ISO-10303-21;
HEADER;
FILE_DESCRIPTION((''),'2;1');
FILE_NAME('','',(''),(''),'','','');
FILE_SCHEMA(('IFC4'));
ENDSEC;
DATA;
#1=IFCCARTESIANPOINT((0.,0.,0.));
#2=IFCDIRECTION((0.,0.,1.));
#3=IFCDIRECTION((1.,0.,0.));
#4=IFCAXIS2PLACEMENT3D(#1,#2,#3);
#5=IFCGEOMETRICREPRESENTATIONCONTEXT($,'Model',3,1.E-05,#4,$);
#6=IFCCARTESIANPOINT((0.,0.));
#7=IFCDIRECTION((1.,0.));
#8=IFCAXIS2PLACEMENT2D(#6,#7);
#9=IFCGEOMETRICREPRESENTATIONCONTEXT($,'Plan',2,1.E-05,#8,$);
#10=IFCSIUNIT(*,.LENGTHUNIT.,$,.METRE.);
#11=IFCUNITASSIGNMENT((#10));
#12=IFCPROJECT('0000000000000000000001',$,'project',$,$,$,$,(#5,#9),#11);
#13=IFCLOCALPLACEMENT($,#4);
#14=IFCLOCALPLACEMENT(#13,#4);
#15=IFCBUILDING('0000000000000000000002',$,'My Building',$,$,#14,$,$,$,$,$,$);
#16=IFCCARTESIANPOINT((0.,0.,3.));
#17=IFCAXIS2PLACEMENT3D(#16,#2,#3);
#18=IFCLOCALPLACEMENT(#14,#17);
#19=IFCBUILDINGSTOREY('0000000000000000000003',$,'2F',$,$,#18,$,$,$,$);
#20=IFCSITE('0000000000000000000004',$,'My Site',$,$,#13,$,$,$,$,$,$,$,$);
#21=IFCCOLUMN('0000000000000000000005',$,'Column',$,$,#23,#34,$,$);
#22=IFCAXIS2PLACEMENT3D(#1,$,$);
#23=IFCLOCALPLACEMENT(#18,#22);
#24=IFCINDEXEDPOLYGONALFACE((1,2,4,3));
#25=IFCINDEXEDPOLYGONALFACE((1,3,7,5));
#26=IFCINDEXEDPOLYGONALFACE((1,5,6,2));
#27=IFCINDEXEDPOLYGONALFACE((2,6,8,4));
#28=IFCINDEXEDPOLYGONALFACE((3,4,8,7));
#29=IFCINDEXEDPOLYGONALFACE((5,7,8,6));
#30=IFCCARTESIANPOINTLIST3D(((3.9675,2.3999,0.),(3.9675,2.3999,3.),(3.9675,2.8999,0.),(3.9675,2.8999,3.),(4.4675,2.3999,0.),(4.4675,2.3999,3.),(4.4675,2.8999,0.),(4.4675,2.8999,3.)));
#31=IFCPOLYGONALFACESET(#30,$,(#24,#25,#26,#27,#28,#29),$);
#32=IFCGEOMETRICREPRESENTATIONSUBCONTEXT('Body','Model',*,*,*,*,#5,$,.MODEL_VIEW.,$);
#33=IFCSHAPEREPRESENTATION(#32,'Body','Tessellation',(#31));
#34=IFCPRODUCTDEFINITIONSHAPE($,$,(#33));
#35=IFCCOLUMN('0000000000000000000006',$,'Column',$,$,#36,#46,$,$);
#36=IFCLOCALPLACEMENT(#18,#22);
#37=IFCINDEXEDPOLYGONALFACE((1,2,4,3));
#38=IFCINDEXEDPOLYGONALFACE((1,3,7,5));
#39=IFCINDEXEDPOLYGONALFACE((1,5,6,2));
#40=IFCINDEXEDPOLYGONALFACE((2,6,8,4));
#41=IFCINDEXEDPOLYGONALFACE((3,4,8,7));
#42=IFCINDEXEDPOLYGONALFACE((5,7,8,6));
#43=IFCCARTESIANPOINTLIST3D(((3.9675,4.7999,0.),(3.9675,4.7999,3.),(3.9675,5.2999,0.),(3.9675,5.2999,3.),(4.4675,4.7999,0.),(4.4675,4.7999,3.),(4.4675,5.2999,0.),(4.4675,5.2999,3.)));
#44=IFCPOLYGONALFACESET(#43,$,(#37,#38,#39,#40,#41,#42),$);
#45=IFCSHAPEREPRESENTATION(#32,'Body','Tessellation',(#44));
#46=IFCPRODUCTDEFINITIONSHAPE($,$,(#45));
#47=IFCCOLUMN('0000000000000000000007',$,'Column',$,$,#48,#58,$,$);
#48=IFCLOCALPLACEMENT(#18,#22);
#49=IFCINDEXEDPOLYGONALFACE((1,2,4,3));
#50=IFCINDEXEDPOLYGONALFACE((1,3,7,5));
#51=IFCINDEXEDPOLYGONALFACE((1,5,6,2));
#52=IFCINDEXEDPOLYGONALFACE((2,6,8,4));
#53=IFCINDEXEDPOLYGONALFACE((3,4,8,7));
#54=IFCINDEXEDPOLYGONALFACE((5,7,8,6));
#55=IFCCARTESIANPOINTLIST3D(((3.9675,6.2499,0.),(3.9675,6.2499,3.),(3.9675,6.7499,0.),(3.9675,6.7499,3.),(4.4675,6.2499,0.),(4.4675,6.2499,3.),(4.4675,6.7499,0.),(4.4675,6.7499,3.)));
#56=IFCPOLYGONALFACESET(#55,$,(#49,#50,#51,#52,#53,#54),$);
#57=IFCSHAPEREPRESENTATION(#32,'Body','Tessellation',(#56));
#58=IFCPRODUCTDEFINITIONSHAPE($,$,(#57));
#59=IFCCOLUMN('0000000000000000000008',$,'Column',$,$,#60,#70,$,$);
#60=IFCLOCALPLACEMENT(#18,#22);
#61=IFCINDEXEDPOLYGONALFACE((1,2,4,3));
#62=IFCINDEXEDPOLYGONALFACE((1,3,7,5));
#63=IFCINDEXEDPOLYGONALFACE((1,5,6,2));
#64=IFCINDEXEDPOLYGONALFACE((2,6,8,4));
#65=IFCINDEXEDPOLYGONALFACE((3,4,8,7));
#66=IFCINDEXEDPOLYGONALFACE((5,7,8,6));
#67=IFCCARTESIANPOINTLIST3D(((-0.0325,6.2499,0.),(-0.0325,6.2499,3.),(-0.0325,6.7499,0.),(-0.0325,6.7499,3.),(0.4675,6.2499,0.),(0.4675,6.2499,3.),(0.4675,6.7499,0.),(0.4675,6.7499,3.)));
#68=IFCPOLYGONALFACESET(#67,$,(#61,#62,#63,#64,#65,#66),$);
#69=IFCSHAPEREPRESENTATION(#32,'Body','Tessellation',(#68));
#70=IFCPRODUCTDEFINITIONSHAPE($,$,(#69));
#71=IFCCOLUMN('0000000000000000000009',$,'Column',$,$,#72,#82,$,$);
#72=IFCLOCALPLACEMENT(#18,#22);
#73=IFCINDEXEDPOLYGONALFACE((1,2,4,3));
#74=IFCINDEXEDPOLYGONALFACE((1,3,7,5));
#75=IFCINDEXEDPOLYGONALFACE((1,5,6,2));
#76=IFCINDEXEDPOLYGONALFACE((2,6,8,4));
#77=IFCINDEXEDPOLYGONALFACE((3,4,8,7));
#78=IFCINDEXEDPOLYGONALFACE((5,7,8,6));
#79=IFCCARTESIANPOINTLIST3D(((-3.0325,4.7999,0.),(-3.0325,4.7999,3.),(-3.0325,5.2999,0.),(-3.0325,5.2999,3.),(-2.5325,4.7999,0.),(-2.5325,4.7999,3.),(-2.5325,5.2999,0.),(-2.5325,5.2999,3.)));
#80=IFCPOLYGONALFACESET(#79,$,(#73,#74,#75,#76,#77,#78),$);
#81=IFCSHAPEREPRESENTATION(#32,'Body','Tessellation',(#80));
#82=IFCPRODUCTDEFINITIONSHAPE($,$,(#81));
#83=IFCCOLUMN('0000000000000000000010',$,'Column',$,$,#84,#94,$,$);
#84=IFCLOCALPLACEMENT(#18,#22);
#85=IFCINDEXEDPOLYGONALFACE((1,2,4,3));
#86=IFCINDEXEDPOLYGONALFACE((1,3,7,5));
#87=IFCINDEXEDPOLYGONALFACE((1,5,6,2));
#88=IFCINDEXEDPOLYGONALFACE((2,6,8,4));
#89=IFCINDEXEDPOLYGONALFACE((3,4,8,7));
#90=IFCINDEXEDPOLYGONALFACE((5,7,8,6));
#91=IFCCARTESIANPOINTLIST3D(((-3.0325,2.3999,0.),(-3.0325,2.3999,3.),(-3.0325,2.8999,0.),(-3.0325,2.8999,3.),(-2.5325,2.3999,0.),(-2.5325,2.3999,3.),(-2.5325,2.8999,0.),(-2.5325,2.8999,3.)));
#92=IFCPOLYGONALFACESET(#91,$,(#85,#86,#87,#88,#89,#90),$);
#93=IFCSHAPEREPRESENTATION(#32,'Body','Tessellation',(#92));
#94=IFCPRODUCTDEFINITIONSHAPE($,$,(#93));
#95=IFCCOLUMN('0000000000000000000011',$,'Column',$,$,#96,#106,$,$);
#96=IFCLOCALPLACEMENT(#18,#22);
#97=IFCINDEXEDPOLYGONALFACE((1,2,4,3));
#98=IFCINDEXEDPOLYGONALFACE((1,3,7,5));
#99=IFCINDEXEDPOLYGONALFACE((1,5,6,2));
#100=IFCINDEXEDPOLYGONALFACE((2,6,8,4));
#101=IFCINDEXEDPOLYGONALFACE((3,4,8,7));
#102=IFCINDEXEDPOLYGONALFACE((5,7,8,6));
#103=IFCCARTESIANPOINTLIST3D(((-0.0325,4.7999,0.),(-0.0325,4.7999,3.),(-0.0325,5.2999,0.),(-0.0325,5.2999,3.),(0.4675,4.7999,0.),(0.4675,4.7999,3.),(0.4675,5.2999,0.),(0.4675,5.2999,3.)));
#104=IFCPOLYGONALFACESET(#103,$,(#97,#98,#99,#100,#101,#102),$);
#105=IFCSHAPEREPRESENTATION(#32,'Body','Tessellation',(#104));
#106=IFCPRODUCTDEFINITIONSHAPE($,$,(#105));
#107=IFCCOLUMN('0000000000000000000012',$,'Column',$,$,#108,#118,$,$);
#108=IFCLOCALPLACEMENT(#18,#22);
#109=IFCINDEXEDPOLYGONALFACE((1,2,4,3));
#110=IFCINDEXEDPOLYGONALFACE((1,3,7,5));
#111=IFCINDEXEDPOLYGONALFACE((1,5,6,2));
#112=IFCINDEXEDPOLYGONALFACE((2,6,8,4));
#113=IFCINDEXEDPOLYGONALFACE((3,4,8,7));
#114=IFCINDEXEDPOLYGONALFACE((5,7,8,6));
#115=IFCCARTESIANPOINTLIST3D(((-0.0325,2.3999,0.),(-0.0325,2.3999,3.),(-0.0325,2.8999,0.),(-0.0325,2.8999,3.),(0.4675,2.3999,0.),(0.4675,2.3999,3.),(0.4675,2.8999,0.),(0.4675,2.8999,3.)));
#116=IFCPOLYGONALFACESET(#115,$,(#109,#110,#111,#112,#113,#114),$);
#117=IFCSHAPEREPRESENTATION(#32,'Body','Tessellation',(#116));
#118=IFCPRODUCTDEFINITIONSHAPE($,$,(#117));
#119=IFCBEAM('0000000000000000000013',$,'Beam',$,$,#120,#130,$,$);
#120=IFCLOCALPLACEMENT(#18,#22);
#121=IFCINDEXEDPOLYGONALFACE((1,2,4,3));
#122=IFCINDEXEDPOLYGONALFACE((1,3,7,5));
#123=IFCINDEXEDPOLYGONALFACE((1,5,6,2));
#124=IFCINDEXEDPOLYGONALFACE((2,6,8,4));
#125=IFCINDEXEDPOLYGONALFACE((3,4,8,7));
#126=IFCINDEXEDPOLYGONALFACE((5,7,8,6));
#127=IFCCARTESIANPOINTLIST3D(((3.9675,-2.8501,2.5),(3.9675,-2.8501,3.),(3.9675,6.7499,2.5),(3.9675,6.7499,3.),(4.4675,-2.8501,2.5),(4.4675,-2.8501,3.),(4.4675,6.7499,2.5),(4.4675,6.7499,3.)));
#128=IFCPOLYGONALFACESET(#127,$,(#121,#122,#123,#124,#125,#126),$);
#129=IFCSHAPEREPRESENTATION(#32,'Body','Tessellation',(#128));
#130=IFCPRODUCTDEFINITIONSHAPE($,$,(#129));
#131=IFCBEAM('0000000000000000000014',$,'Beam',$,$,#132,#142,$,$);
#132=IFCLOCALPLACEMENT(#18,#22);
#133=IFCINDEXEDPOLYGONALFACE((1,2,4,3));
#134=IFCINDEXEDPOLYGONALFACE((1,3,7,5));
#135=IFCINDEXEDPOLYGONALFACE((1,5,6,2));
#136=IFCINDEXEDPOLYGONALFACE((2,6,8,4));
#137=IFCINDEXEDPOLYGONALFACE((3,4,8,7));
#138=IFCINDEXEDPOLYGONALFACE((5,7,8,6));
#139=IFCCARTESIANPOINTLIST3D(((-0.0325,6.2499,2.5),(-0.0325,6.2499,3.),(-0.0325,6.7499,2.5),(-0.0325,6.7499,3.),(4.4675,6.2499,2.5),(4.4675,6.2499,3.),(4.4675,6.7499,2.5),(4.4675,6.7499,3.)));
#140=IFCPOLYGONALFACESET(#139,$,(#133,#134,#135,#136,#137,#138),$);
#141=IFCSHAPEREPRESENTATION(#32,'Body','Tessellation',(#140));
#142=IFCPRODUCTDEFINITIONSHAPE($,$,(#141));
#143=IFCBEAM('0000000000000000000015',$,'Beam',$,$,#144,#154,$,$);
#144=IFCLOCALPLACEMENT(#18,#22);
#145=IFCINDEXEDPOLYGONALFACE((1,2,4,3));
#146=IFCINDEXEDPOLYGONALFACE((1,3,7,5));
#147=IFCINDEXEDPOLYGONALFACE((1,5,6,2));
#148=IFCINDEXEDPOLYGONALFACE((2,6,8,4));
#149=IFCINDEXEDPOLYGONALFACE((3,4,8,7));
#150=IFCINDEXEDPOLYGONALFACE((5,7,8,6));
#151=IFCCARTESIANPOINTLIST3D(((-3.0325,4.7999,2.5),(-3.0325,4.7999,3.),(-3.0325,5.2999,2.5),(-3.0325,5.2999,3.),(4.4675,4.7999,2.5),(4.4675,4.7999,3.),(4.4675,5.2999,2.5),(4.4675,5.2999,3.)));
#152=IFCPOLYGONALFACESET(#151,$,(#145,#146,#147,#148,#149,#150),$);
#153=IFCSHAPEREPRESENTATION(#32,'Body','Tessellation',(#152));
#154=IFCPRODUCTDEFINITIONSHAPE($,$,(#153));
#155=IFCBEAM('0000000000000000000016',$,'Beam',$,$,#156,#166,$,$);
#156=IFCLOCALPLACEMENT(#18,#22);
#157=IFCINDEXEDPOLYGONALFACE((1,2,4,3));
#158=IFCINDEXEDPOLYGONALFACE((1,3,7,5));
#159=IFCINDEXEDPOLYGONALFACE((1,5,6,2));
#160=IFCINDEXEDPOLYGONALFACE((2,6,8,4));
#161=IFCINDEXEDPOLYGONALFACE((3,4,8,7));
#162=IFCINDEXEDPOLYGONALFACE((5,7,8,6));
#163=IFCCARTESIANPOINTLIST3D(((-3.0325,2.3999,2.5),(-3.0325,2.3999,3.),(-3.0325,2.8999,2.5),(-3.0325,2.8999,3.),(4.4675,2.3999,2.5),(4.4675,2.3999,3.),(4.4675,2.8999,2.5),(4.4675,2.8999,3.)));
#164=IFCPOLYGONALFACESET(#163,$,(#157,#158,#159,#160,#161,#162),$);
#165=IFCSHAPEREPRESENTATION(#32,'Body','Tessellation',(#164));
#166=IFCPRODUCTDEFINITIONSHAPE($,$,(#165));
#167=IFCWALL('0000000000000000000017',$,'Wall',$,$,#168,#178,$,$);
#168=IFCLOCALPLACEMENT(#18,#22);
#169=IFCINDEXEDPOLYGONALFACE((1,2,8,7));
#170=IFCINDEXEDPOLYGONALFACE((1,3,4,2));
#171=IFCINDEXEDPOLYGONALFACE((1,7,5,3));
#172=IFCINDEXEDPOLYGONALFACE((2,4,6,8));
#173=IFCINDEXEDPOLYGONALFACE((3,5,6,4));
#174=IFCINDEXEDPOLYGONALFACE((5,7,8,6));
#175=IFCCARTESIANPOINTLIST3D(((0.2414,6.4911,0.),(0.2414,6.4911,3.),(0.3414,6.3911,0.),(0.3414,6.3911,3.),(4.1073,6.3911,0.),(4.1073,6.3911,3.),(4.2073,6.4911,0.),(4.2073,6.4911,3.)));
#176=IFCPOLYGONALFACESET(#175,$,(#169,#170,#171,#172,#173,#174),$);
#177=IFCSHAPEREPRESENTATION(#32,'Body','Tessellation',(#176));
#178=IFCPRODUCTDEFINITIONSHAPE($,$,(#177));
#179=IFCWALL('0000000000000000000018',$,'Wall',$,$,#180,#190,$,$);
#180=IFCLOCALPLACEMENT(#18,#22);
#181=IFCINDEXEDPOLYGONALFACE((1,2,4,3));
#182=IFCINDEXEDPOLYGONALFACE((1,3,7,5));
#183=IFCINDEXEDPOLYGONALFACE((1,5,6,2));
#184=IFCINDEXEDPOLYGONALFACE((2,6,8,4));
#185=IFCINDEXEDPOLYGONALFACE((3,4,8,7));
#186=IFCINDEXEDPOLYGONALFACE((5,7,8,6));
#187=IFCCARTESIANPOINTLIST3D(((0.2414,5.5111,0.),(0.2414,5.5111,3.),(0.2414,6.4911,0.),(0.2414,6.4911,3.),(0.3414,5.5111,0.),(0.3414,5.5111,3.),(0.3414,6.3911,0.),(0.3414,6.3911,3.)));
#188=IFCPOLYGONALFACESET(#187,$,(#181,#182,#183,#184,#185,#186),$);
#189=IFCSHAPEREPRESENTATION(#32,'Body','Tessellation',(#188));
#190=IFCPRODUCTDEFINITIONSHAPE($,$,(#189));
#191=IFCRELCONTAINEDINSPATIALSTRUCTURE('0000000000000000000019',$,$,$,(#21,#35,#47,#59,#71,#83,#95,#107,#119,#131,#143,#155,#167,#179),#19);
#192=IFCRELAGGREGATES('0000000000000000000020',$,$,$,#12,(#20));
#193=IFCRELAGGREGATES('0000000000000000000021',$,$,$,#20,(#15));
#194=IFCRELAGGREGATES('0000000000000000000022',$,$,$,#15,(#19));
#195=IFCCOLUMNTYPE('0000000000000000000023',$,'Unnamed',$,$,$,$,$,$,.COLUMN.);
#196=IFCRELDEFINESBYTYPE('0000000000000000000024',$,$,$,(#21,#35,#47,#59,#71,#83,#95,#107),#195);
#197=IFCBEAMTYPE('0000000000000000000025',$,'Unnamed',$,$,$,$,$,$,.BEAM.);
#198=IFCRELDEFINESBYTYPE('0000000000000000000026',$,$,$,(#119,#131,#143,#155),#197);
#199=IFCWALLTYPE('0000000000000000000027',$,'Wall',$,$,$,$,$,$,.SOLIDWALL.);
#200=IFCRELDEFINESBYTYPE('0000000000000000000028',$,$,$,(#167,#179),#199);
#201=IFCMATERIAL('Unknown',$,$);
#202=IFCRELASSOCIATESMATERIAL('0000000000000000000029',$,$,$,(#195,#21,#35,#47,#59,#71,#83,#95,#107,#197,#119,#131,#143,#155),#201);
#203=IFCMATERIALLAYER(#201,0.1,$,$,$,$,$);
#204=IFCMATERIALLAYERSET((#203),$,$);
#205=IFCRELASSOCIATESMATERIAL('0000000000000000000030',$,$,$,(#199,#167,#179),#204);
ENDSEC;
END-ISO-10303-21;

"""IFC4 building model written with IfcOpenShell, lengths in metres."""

from ifc_helpers import new_model, si_unit, frame, origin_with_axes, origin_2d_with_axis, place, context, subcontext, project, spatial, line, indexed_curve, rectangle, outline, extrude, material, layer, layer_set, layer_usage, material_profile, profile_set, profile_usage, type_object, element, save


model = new_model("IFC4")

# Units and contexts
model_context = context("Model", 3, precision=1e-05, world=origin_with_axes())
plan_context = context("Plan", 2, precision=1e-05, world=origin_2d_with_axis())
body_context_1 = subcontext(model_context, "Body", "Model", "MODEL_VIEW")
ifc_project = project(units=[si_unit("LENGTHUNIT", "METRE")], contexts=[model_context, plan_context])

# Site, building, storey
site_placement = place(None, origin_with_axes())
site = spatial("IfcSite", under=ifc_project, at=site_placement, Name="My Site")
building_placement = place(site_placement, origin_with_axes())
building = spatial("IfcBuilding", under=site, at=building_placement, Name="My Building")
storey_placement = place(building_placement, frame((0.0, 0.0, 3.0), z_axis=(0.0, 0.0, 1.0), x_axis=(1.0, 0.0, 0.0)))
storey = spatial("IfcBuildingStorey", under=building, at=storey_placement, Name="2F")

# Columns
ifc_material = material(Name="Unknown")
ifc_material_profile_1 = material_profile(ifc_material, rectangle(XDim=0.5, YDim=0.5))
ifc_profile_set_1 = profile_set([ifc_material_profile_1])
ifc_profile_usage_1 = profile_usage(ifc_profile_set_1, cardinal=7)
column_type = type_object("IfcColumnType", Name="Unnamed", PredefinedType="COLUMN", material=ifc_profile_set_1)
column_1_placement = place(storey_placement, frame((4.4675, 2.8999, 0.0), z_axis=(0.0, 0.0, 1.0), x_axis=(1.0, 0.0, 0.0)))
element("IfcColumn", 1, at=column_1_placement, inside=storey, type_object=column_type, material=ifc_profile_usage_1, Name="Column", context=body_context_1, shape_type="SweptSolid", body=[
    extrude(rectangle(XDim=0.5, YDim=0.5), frame((-0.25, -0.25, 0.0), z_axis=(0.0, 0.0, 1.0), x_axis=(1.0, 0.0, 0.0)), (0.0, 0.0, 1.0), 3.0),
])
ifc_profile_usage_2 = profile_usage(ifc_profile_set_1, cardinal=7)
column_2_placement = place(storey_placement, frame((4.4675, 5.2999, 0.0), z_axis=(0.0, 0.0, 1.0), x_axis=(1.0, 0.0, 0.0)))
element("IfcColumn", 2, at=column_2_placement, inside=storey, type_object=column_type, material=ifc_profile_usage_2, Name="Column", context=body_context_1, shape_type="SweptSolid", body=[
    extrude(rectangle(XDim=0.5, YDim=0.5), frame((-0.25, -0.25, 0.0), z_axis=(0.0, 0.0, 1.0), x_axis=(1.0, 0.0, 0.0)), (0.0, 0.0, 1.0), 3.0),
])
ifc_profile_usage_3 = profile_usage(ifc_profile_set_1, cardinal=7)
column_3_placement = place(storey_placement, frame((4.4675, 6.7499, 0.0), z_axis=(0.0, 0.0, 1.0), x_axis=(1.0, 0.0, 0.0)))
element("IfcColumn", 3, at=column_3_placement, inside=storey, type_object=column_type, material=ifc_profile_usage_3, Name="Column", context=body_context_1, shape_type="SweptSolid", body=[
    extrude(rectangle(XDim=0.5, YDim=0.5), frame((-0.25, -0.25, 0.0), z_axis=(0.0, 0.0, 1.0), x_axis=(1.0, 0.0, 0.0)), (0.0, 0.0, 1.0), 3.0),
])
ifc_profile_usage_4 = profile_usage(ifc_profile_set_1, cardinal=7)
column_4_placement = place(storey_placement, frame((0.4675, 6.7499, 0.0), z_axis=(0.0, 0.0, 1.0), x_axis=(1.0, 0.0, 0.0)))
element("IfcColumn", 4, at=column_4_placement, inside=storey, type_object=column_type, material=ifc_profile_usage_4, Name="Column", context=body_context_1, shape_type="SweptSolid", body=[
    extrude(rectangle(XDim=0.5, YDim=0.5), frame((-0.25, -0.25, 0.0), z_axis=(0.0, 0.0, 1.0), x_axis=(1.0, 0.0, 0.0)), (0.0, 0.0, 1.0), 3.0),
])
ifc_profile_usage_5 = profile_usage(ifc_profile_set_1, cardinal=9)
column_5_placement = place(storey_placement, frame((-3.0325, 5.2999, 0.0), z_axis=(0.0, 0.0, 1.0), x_axis=(1.0, 0.0, 0.0)))
element("IfcColumn", 5, at=column_5_placement, inside=storey, type_object=column_type, material=ifc_profile_usage_5, Name="Column", context=body_context_1, shape_type="SweptSolid", body=[
    extrude(rectangle(XDim=0.5, YDim=0.5), frame((0.25, -0.25, 0.0), z_axis=(0.0, 0.0, 1.0), x_axis=(1.0, 0.0, 0.0)), (0.0, 0.0, 1.0), 3.0),
])
ifc_profile_usage_6 = profile_usage(ifc_profile_set_1, cardinal=9)
column_6_placement = place(storey_placement, frame((-3.0325, 2.8999, 0.0), z_axis=(0.0, 0.0, 1.0), x_axis=(1.0, 0.0, 0.0)))
element("IfcColumn", 6, at=column_6_placement, inside=storey, type_object=column_type, material=ifc_profile_usage_6, Name="Column", context=body_context_1, shape_type="SweptSolid", body=[
    extrude(rectangle(XDim=0.5, YDim=0.5), frame((0.25, -0.25, 0.0), z_axis=(0.0, 0.0, 1.0), x_axis=(1.0, 0.0, 0.0)), (0.0, 0.0, 1.0), 3.0),
])
ifc_profile_usage_7 = profile_usage(ifc_profile_set_1, cardinal=9)
column_7_placement = place(storey_placement, frame((-0.0325, 5.2999, 0.0), z_axis=(0.0, 0.0, 1.0), x_axis=(1.0, 0.0, 0.0)))
element("IfcColumn", 7, at=column_7_placement, inside=storey, type_object=column_type, material=ifc_profile_usage_7, Name="Column", context=body_context_1, shape_type="SweptSolid", body=[
    extrude(rectangle(XDim=0.5, YDim=0.5), frame((0.25, -0.25, 0.0), z_axis=(0.0, 0.0, 1.0), x_axis=(1.0, 0.0, 0.0)), (0.0, 0.0, 1.0), 3.0),
])
ifc_profile_usage_8 = profile_usage(ifc_profile_set_1, cardinal=9)
column_8_placement = place(storey_placement, frame((-0.0325, 2.8999, 0.0), z_axis=(0.0, 0.0, 1.0), x_axis=(1.0, 0.0, 0.0)))
element("IfcColumn", 8, at=column_8_placement, inside=storey, type_object=column_type, material=ifc_profile_usage_8, Name="Column", context=body_context_1, shape_type="SweptSolid", body=[
    extrude(rectangle(XDim=0.5, YDim=0.5), frame((0.25, -0.25, 0.0), z_axis=(0.0, 0.0, 1.0), x_axis=(1.0, 0.0, 0.0)), (0.0, 0.0, 1.0), 3.0),
])

# Beams
ifc_material_profile_2 = material_profile(ifc_material, rectangle(XDim=0.5, YDim=0.5))
ifc_profile_set_2 = profile_set([ifc_material_profile_2])
ifc_profile_usage_9 = profile_usage(ifc_profile_set_2, cardinal=7)
beam_type = type_object("IfcBeamType", Name="Unnamed", PredefinedType="BEAM", material=ifc_profile_set_2)
beam_1_placement = place(storey_placement, frame((4.4675, 6.7499, 3.0), z_axis=(0.0, -1.0, 0.0), x_axis=(1.0, 0.0, 0.0)))
element("IfcBeam", 9, at=beam_1_placement, inside=storey, type_object=beam_type, material=ifc_profile_usage_9, Name="Beam", context=body_context_1, shape_type="SweptSolid", body=[
    extrude(rectangle(XDim=0.5, YDim=0.5), frame((-0.25, -0.25, 0.0), z_axis=(0.0, 0.0, 1.0), x_axis=(1.0, 0.0, 0.0)), (0.0, 0.0, 1.0), 9.6),
])
ifc_profile_usage_10 = profile_usage(ifc_profile_set_2, cardinal=9)
beam_2_placement = place(storey_placement, frame((4.4675, 6.7499, 3.0), z_axis=(-1.0, 0.0, 0.0), x_axis=(0.0, -1.0, 0.0)))
element("IfcBeam", 10, at=beam_2_placement, inside=storey, type_object=beam_type, material=ifc_profile_usage_10, Name="Beam", context=body_context_1, shape_type="SweptSolid", body=[
    extrude(rectangle(XDim=0.5, YDim=0.5), frame((0.25, -0.25, 0.0), z_axis=(0.0, 0.0, 1.0), x_axis=(1.0, 0.0, 0.0)), (0.0, 0.0, 1.0), 4.5),
])
ifc_profile_usage_11 = profile_usage(ifc_profile_set_2, cardinal=9)
beam_3_placement = place(storey_placement, frame((4.4675, 5.2999, 3.0), z_axis=(-1.0, 0.0, 0.0), x_axis=(0.0, -1.0, 0.0)))
element("IfcBeam", 11, at=beam_3_placement, inside=storey, type_object=beam_type, material=ifc_profile_usage_11, Name="Beam", context=body_context_1, shape_type="SweptSolid", body=[
    extrude(rectangle(XDim=0.5, YDim=0.5), frame((0.25, -0.25, 0.0), z_axis=(0.0, 0.0, 1.0), x_axis=(1.0, 0.0, 0.0)), (0.0, 0.0, 1.0), 7.5),
])
ifc_profile_usage_12 = profile_usage(ifc_profile_set_2, cardinal=9)
beam_4_placement = place(storey_placement, frame((4.4675, 2.8999, 3.0), z_axis=(-1.0, 0.0, 0.0), x_axis=(0.0, -1.0, 0.0)))
element("IfcBeam", 12, at=beam_4_placement, inside=storey, type_object=beam_type, material=ifc_profile_usage_12, Name="Beam", context=body_context_1, shape_type="SweptSolid", body=[
    extrude(rectangle(XDim=0.5, YDim=0.5), frame((0.25, -0.25, 0.0), z_axis=(0.0, 0.0, 1.0), x_axis=(1.0, 0.0, 0.0)), (0.0, 0.0, 1.0), 7.5),
])

# Walls
ifc_layer = layer(ifc_material, 0.1)
ifc_layer_set = layer_set([ifc_layer])
ifc_layer_usage_1 = layer_usage(ifc_layer_set, "AXIS2", "POSITIVE", 0.0)
wall_type = type_object("IfcWallType", Name="Wall", PredefinedType="SOLIDWALL", material=ifc_layer_set)
wall_1_placement = place(storey_placement, frame((4.2073, 6.4911, 0.0), z_axis=(0.0, 0.0, 1.0), x_axis=(-1.0, 0.0, 0.0)))
element("IfcWall", 13, at=wall_1_placement, inside=storey, type_object=wall_type, material=ifc_layer_usage_1, Name="Wall", context=body_context_1, shape_type="SweptSolid", body=[
    extrude(outline(indexed_curve([(0.0, 0.0), (0.1, 0.1), (3.8658, 0.1), (3.9658, 0.0)], segments=[line(1, 2, 3, 4, 1)])), origin_with_axes(), (0.0, 0.0, 1.0), 3.0),
])
ifc_layer_usage_2 = layer_usage(ifc_layer_set, "AXIS2", "POSITIVE", 0.0)
wall_2_placement = place(storey_placement, frame((0.2414, 6.4911, 0.0), z_axis=(0.0, 0.0, 1.0), x_axis=(0.0, -1.0, 0.0)))
element("IfcWall", 14, at=wall_2_placement, inside=storey, type_object=wall_type, material=ifc_layer_usage_2, Name="Wall", context=body_context_1, shape_type="SweptSolid", body=[
    extrude(outline(indexed_curve([(0.0, 0.0), (0.1, 0.1), (0.98, 0.1), (0.98, 0.0)], segments=[line(1, 2, 3, 4, 1)])), origin_with_axes(), (0.0, 0.0, 1.0), 3.0),
])

save(model, "model.ifc")
